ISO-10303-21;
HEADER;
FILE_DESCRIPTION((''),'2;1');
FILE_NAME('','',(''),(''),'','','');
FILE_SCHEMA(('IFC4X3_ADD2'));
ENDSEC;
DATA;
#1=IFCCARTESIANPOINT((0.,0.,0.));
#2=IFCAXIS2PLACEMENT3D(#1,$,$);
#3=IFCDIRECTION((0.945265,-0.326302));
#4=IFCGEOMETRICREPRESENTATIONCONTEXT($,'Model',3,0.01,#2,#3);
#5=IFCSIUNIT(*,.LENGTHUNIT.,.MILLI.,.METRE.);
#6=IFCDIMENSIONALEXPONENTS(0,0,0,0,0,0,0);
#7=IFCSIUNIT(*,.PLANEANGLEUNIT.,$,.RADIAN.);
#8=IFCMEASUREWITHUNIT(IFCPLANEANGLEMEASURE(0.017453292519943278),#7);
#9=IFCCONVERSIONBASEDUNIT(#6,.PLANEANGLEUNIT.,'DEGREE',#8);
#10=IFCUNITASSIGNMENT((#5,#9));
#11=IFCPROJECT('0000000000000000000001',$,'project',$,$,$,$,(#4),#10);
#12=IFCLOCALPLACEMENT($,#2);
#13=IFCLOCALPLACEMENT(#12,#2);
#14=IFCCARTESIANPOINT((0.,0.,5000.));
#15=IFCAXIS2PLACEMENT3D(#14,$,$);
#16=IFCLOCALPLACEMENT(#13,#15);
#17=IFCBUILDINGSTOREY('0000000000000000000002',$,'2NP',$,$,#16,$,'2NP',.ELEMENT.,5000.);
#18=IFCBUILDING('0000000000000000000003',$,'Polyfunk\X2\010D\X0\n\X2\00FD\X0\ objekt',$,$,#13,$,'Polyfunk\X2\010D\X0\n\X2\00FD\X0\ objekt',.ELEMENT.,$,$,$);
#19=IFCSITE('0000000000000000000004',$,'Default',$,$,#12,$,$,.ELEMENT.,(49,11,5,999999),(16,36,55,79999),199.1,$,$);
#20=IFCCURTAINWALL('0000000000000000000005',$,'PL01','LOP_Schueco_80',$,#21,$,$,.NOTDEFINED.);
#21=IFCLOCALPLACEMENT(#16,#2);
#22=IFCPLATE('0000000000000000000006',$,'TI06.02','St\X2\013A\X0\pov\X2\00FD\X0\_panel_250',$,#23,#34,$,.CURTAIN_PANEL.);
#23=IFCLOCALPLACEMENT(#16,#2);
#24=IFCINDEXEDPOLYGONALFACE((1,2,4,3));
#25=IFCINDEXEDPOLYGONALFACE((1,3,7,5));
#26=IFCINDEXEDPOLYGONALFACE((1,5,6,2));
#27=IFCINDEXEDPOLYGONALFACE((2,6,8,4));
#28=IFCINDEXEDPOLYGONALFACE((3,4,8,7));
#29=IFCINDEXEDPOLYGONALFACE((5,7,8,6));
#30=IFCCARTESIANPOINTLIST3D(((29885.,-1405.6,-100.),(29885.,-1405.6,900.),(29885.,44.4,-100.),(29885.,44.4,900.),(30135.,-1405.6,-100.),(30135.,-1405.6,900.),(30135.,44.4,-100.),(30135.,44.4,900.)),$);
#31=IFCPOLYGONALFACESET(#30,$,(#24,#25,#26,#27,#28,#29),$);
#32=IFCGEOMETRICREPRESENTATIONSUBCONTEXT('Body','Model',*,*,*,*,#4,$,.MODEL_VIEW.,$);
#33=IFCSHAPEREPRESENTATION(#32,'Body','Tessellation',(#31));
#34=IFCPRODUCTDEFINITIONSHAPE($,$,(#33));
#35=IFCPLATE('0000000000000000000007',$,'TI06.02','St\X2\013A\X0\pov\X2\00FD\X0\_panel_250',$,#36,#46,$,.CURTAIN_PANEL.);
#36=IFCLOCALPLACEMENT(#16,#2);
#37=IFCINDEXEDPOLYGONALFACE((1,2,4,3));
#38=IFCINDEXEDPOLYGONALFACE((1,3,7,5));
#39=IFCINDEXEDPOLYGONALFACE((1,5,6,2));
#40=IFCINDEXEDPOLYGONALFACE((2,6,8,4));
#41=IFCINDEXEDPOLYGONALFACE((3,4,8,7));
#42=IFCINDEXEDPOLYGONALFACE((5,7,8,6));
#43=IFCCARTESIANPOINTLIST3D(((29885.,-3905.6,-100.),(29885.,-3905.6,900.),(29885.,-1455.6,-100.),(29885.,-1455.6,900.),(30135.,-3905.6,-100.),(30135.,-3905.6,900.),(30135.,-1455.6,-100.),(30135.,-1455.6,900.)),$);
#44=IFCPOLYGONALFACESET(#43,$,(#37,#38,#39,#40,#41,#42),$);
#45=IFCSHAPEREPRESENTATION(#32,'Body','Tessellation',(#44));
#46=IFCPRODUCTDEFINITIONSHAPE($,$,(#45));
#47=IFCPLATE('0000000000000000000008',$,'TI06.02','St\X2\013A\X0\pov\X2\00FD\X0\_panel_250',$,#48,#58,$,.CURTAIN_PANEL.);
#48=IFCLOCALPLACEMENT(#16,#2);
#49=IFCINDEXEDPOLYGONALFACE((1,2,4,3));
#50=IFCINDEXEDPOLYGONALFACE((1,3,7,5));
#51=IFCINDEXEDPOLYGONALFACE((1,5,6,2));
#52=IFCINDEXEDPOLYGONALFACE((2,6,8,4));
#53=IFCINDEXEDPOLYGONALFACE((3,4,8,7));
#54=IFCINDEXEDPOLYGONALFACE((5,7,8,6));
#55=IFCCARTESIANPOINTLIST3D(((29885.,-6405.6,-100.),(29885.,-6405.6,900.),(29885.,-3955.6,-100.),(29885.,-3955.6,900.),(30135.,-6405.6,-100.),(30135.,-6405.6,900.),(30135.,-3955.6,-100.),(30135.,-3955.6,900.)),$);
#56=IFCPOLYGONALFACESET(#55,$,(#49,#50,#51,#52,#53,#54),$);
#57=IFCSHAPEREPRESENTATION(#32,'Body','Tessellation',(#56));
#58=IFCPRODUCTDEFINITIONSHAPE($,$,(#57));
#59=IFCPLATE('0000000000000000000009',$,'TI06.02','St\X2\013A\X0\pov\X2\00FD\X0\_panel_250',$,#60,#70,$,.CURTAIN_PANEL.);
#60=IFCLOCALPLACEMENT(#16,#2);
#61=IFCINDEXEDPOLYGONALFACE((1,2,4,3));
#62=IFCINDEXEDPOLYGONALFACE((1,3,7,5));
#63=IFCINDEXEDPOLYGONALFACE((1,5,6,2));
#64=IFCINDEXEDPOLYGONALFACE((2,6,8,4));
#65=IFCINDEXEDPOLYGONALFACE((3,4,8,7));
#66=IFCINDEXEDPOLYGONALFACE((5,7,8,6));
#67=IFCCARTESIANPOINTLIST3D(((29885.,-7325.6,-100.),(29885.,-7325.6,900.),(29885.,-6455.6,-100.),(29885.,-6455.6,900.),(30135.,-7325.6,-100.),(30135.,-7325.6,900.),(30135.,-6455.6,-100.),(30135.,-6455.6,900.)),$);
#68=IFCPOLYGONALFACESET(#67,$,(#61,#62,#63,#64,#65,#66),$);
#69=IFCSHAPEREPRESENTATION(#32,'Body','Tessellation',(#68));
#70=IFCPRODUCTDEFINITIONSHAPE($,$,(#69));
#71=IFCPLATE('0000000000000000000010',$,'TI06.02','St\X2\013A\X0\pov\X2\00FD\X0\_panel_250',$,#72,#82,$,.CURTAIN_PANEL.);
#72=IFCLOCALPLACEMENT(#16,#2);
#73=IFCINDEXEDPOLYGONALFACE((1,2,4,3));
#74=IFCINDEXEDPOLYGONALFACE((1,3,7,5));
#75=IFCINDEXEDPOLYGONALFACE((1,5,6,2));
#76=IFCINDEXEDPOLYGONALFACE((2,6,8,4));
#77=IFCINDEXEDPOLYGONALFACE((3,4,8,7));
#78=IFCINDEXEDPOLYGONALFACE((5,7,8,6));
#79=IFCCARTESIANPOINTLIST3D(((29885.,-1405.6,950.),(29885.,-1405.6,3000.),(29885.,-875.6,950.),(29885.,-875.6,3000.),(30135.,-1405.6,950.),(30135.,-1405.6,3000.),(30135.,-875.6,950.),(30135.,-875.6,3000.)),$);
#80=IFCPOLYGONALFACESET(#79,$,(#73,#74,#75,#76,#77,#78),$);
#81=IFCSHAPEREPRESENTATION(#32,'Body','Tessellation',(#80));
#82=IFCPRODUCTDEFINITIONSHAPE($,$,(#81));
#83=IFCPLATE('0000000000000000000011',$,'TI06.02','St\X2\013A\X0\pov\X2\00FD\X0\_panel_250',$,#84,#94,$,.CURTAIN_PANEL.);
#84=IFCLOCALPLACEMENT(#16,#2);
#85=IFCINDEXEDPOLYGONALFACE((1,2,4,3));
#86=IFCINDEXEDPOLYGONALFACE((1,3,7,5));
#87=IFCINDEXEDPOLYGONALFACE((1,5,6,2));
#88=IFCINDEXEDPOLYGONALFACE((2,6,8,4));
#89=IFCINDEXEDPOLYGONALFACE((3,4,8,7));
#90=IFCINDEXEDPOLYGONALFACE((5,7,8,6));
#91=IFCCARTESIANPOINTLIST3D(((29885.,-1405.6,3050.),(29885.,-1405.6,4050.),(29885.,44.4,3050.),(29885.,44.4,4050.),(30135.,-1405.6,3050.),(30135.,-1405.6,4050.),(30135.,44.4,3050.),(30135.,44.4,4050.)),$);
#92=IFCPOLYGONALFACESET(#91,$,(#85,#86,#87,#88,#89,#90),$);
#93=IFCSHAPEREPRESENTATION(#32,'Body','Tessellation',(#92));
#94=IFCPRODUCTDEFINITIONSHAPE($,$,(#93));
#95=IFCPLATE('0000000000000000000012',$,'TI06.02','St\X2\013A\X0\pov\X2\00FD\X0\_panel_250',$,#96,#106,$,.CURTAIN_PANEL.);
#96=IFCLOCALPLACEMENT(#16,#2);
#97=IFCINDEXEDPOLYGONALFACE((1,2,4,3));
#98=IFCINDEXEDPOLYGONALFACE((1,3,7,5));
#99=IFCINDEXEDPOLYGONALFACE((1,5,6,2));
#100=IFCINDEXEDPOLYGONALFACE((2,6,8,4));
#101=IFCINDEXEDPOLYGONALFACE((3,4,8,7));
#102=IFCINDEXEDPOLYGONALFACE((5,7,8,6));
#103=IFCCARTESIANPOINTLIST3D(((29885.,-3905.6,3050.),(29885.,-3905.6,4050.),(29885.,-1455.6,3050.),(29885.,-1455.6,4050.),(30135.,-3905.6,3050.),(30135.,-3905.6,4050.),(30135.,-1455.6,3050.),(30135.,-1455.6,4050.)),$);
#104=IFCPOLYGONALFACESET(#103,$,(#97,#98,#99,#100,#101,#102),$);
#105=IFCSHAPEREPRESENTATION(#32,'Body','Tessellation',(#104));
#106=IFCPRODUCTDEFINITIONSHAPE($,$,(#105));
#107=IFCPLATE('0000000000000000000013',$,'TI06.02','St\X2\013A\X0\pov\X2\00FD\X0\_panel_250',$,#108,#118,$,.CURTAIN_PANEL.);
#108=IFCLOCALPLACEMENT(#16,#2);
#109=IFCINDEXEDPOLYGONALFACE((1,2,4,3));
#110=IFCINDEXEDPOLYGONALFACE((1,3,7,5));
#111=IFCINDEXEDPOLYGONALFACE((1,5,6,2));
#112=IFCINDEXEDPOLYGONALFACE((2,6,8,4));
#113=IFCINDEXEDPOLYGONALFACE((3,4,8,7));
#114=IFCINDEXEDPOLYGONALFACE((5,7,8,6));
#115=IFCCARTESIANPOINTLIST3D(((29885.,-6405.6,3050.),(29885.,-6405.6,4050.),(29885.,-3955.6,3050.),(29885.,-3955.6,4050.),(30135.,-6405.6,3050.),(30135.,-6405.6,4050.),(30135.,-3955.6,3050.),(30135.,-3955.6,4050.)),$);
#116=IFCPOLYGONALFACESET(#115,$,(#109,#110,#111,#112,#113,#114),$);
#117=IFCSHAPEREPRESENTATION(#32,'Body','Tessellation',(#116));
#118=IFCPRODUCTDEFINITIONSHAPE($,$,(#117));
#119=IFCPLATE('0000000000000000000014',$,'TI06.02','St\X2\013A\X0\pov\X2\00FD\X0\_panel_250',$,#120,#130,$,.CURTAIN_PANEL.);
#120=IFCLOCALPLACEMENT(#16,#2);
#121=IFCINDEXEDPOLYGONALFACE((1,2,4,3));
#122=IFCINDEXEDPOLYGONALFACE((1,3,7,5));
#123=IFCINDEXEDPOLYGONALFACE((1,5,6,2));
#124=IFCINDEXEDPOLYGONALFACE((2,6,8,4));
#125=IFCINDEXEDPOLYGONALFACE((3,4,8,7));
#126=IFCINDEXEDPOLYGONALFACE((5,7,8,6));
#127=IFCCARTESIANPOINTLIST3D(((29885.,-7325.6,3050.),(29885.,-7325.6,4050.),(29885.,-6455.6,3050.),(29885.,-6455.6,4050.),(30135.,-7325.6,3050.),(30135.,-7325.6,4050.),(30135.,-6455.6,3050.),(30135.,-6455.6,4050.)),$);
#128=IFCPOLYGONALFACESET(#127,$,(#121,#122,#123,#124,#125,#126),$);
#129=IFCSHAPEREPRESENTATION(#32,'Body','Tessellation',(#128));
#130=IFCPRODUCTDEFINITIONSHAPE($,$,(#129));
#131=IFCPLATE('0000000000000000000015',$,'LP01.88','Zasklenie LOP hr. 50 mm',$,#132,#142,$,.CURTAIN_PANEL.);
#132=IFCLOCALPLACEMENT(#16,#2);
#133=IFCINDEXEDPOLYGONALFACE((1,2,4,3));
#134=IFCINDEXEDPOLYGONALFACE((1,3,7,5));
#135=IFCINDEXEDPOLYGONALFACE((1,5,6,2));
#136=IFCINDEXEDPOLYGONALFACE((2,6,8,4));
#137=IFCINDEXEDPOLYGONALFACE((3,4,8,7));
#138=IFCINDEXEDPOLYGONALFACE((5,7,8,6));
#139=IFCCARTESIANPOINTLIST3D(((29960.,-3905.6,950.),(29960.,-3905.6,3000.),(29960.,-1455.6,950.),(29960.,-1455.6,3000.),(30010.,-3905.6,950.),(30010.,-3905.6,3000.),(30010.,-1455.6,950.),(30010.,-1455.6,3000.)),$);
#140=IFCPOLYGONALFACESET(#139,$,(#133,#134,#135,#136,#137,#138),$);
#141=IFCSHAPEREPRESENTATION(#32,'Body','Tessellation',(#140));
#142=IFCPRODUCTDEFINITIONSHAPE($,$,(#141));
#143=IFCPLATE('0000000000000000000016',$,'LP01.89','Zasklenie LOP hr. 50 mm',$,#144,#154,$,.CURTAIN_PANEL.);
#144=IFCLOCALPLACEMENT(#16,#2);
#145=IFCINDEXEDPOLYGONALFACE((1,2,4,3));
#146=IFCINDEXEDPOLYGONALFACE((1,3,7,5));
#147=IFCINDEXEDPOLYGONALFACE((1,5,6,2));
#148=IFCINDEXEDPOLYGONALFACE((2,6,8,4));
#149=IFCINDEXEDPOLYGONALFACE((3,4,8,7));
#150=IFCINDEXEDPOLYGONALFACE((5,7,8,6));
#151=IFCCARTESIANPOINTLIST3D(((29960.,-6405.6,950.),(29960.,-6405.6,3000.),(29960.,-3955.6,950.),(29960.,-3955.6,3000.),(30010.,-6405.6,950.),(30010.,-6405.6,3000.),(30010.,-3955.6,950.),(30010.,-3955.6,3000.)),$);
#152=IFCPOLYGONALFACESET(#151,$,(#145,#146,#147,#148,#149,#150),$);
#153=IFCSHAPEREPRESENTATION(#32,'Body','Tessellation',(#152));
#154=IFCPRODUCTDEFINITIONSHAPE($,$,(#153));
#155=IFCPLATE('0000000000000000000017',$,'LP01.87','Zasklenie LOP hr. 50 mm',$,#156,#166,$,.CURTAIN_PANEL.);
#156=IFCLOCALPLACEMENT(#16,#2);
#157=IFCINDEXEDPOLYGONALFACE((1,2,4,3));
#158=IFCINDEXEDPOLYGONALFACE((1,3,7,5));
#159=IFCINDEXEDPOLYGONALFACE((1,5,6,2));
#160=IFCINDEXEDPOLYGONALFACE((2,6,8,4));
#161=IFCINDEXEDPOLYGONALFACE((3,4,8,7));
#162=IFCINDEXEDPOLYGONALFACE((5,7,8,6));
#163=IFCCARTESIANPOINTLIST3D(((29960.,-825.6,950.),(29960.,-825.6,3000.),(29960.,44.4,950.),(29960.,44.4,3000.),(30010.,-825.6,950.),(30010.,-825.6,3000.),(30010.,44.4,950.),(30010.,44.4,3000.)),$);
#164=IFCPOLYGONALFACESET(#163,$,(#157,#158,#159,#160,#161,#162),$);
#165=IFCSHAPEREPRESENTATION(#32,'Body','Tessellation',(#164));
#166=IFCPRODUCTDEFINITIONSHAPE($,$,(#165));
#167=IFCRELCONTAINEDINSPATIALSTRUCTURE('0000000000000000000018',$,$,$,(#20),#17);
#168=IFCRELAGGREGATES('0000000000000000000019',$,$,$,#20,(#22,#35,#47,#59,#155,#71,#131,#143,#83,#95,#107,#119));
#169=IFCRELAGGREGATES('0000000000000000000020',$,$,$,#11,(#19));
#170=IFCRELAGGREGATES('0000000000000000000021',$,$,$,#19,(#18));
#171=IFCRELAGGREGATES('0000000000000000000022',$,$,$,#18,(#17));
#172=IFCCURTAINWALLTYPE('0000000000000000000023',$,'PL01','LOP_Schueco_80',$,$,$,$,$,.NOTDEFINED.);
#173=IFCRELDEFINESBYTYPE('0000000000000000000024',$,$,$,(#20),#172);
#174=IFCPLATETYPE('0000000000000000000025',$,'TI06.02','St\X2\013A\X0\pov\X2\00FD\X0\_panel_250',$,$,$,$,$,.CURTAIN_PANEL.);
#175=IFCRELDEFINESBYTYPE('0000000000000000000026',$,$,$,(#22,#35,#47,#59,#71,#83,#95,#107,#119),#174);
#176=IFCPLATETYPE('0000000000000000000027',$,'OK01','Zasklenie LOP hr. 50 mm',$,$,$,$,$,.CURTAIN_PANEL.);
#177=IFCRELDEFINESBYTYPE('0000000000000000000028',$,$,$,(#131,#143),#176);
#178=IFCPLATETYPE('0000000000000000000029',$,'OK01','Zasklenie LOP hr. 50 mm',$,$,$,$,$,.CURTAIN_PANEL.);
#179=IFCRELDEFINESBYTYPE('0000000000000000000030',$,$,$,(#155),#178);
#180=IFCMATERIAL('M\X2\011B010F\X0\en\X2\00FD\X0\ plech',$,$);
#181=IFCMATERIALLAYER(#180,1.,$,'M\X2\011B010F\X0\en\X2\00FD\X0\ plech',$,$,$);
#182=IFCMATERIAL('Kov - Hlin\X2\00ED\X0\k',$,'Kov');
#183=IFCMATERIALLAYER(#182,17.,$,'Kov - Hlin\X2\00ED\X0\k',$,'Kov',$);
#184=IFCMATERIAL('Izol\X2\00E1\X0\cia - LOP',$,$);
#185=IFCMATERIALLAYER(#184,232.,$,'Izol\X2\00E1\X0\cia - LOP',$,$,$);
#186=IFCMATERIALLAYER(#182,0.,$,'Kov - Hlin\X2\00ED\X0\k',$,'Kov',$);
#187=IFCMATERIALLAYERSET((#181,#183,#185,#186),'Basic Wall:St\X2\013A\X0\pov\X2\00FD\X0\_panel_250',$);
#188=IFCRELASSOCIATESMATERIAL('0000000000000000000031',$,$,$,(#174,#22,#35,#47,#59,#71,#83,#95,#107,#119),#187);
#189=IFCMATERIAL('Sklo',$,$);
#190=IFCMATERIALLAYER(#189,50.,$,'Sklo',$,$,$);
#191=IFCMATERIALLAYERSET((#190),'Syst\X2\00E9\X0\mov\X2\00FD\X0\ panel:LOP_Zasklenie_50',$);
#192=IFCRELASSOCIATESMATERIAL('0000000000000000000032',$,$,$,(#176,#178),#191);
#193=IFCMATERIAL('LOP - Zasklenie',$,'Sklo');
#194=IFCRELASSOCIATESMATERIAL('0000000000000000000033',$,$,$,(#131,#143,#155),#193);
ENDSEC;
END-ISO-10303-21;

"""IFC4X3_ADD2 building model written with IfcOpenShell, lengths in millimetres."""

from ifc_helpers import new_model, entity, si_unit, converted_unit, direction, frame, frame_2d, origin, origin_2d_with_axis, place, context, subcontext, project, spatial, rectangle, extrude, source, transform, mapped, material, layer, layer_set, layer_usage, type_object, type_shapes, element, aggregate, save


model = new_model("IFC4X3_ADD2")

# Units and contexts
model_context = context("Model", 3, precision=0.01, world=origin(), true_north=direction((0.945265, -0.326302)))
body_context = subcontext(model_context, "Body", "Model", "MODEL_VIEW")
ifc_project = project(units=[si_unit("LENGTHUNIT", "METRE", prefix="MILLI"), converted_unit("PLANEANGLEUNIT", "DEGREE", entity("IfcPlaneAngleMeasure", 0.017453292519943278), si_unit("PLANEANGLEUNIT", "RADIAN"), dimensions=[0, 0, 0, 0, 0, 0, 0])], contexts=[model_context])

# Site, building, storey
site_placement = place(None, origin())
site = spatial("IfcSite", under=ifc_project, at=site_placement, Name="Default", CompositionType="ELEMENT", RefLatitude=(49, 11, 5, 999999), RefLongitude=(16, 36, 55, 79999), RefElevation=199.1)
building_placement = place(site_placement, origin())
building = spatial("IfcBuilding", under=site, at=building_placement, Name="Polyfunkčný objekt", LongName="Polyfunkčný objekt", CompositionType="ELEMENT")
storey_placement = place(building_placement, frame((0.0, 0.0, 5000.0)))
storey = spatial("IfcBuildingStorey", under=building, at=storey_placement, Name="2NP", LongName="2NP", CompositionType="ELEMENT", Elevation=5000.0)

# Curtain wall, plates
curtain_wall_type = type_object("IfcCurtainWallType", Name="PL01", Description="LOP_Schueco_80", PredefinedType="NOTDEFINED")
curtain_wall_placement = place(storey_placement, frame((0.0, 0.0, -5000.0)))
curtain_wall = element("IfcCurtainWall", 1, at=curtain_wall_placement, inside=storey, type_object=curtain_wall_type, Name="PL01", Description="LOP_Schueco_80", PredefinedType="NOTDEFINED")
ifc_material_1 = material(Name="Měďený plech")
ifc_layer_1 = layer(ifc_material_1, 1.0, Name="Měďený plech")
ifc_material_2 = material(Name="Kov - Hliník", Category="Kov")
ifc_layer_2 = layer(ifc_material_2, 17.0, Name="Kov - Hliník", Category="Kov")
ifc_material_3 = material(Name="Izolácia - LOP")
ifc_layer_3 = layer(ifc_material_3, 232.0, Name="Izolácia - LOP")
ifc_layer_4 = layer(ifc_material_2, 0.0, Name="Kov - Hliník", Category="Kov")
ifc_layer_set_1 = layer_set([ifc_layer_1, ifc_layer_2, ifc_layer_3, ifc_layer_4], Name="Basic Wall:Stĺpový_panel_250")
ifc_layer_usage_1 = layer_usage(ifc_layer_set_1, "AXIS2", "POSITIVE", -125.0)
plate_type_1 = type_object("IfcPlateType", Name="TI06.02", Description="Stĺpový_panel_250", PredefinedType="CURTAIN_PANEL", material=ifc_layer_set_1)
plate_1_placement = place(storey_placement, frame((30010.0, 44.4, -100.0), z_axis=(0.0, 0.0, 1.0), x_axis=(0.0, -1.0, 0.0)))
plate_1 = element("IfcPlate", 2, at=plate_1_placement, type_object=plate_type_1, material=ifc_layer_usage_1, Name="TI06.02", Description="Stĺpový_panel_250", PredefinedType="CURTAIN_PANEL", context=body_context, shape_type="SweptSolid", body=[
    extrude(rectangle(XDim=250.0, YDim=1450.0, at=frame_2d((0.0, 0.0), x_axis=(1.0, 0.0))), frame((725.0, 0.0, 0.0), z_axis=(0.0, 0.0, 1.0), x_axis=(0.0, 1.0, 0.0)), (0.0, 0.0, 1.0), 1000.0),
])
ifc_layer_usage_2 = layer_usage(ifc_layer_set_1, "AXIS2", "POSITIVE", -125.0)
plate_2_placement = place(storey_placement, frame((30010.0, -1455.6, -100.0), z_axis=(0.0, 0.0, 1.0), x_axis=(0.0, -1.0, 0.0)))
plate_2 = element("IfcPlate", 3, at=plate_2_placement, type_object=plate_type_1, material=ifc_layer_usage_2, Name="TI06.02", Description="Stĺpový_panel_250", PredefinedType="CURTAIN_PANEL", context=body_context, shape_type="SweptSolid", body=[
    extrude(rectangle(XDim=250.0, YDim=2450.0, at=origin_2d_with_axis()), frame((1225.0, 0.0, 0.0), z_axis=(0.0, 0.0, 1.0), x_axis=(0.0, 1.0, 0.0)), (0.0, 0.0, 1.0), 1000.0),
])
ifc_layer_usage_3 = layer_usage(ifc_layer_set_1, "AXIS2", "POSITIVE", -125.0)
plate_3_placement = place(storey_placement, frame((30010.0, -3955.6, -100.0), z_axis=(0.0, 0.0, 1.0), x_axis=(0.0, -1.0, 0.0)))
plate_3 = element("IfcPlate", 4, at=plate_3_placement, type_object=plate_type_1, material=ifc_layer_usage_3, Name="TI06.02", Description="Stĺpový_panel_250", PredefinedType="CURTAIN_PANEL", context=body_context, shape_type="SweptSolid", body=[
    extrude(rectangle(XDim=250.0, YDim=2450.0, at=frame_2d((0.0, 0.0), x_axis=(1.0, 0.0))), frame((1225.0, 0.0, 0.0), z_axis=(0.0, 0.0, 1.0), x_axis=(0.0, 1.0, 0.0)), (0.0, 0.0, 1.0), 1000.0),
])
ifc_layer_usage_4 = layer_usage(ifc_layer_set_1, "AXIS2", "POSITIVE", -125.0)
plate_4_placement = place(storey_placement, frame((30010.0, -6455.6, -100.0), z_axis=(0.0, 0.0, 1.0), x_axis=(0.0, -1.0, 0.0)))
plate_4 = element("IfcPlate", 5, at=plate_4_placement, type_object=plate_type_1, material=ifc_layer_usage_4, Name="TI06.02", Description="Stĺpový_panel_250", PredefinedType="CURTAIN_PANEL", context=body_context, shape_type="SweptSolid", body=[
    extrude(rectangle(XDim=250.0, YDim=870.0, at=frame_2d((0.0, 0.0), x_axis=(1.0, 0.0))), frame((435.0, 0.0, 0.0), z_axis=(0.0, 0.0, 1.0), x_axis=(0.0, 1.0, 0.0)), (0.0, 0.0, 1.0), 1000.0),
])
ifc_layer_usage_5 = layer_usage(ifc_layer_set_1, "AXIS2", "POSITIVE", -125.0)
plate_5_placement = place(storey_placement, frame((30010.0, -875.6, 950.0), z_axis=(0.0, 0.0, 1.0), x_axis=(0.0, -1.0, 0.0)))
plate_5 = element("IfcPlate", 6, at=plate_5_placement, type_object=plate_type_1, material=ifc_layer_usage_5, Name="TI06.02", Description="Stĺpový_panel_250", PredefinedType="CURTAIN_PANEL", context=body_context, shape_type="SweptSolid", body=[
    extrude(rectangle(XDim=250.0, YDim=530.0, at=frame_2d((0.0, 0.0), x_axis=(1.0, 0.0))), frame((265.0, 0.0, 0.0), z_axis=(0.0, 0.0, 1.0), x_axis=(0.0, 1.0, 0.0)), (0.0, 0.0, 1.0), 2050.0),
])
ifc_layer_usage_6 = layer_usage(ifc_layer_set_1, "AXIS2", "POSITIVE", -125.0)
plate_6_placement = place(storey_placement, frame((30010.0, 44.4, 3050.0), z_axis=(0.0, 0.0, 1.0), x_axis=(0.0, -1.0, 0.0)))
plate_6 = element("IfcPlate", 7, at=plate_6_placement, type_object=plate_type_1, material=ifc_layer_usage_6, Name="TI06.02", Description="Stĺpový_panel_250", PredefinedType="CURTAIN_PANEL", context=body_context, shape_type="SweptSolid", body=[
    extrude(rectangle(XDim=250.0, YDim=1450.0, at=frame_2d((0.0, 0.0), x_axis=(1.0, 0.0))), frame((725.0, 0.0, 0.0), z_axis=(0.0, 0.0, 1.0), x_axis=(0.0, 1.0, 0.0)), (0.0, 0.0, 1.0), 1000.0),
])
ifc_layer_usage_7 = layer_usage(ifc_layer_set_1, "AXIS2", "POSITIVE", -125.0)
plate_7_placement = place(storey_placement, frame((30010.0, -1455.6, 3050.0), z_axis=(0.0, 0.0, 1.0), x_axis=(0.0, -1.0, 0.0)))
plate_7 = element("IfcPlate", 8, at=plate_7_placement, type_object=plate_type_1, material=ifc_layer_usage_7, Name="TI06.02", Description="Stĺpový_panel_250", PredefinedType="CURTAIN_PANEL", context=body_context, shape_type="SweptSolid", body=[
    extrude(rectangle(XDim=250.0, YDim=2450.0, at=origin_2d_with_axis()), frame((1225.0, 0.0, 0.0), z_axis=(0.0, 0.0, 1.0), x_axis=(0.0, 1.0, 0.0)), (0.0, 0.0, 1.0), 1000.0),
])
ifc_layer_usage_8 = layer_usage(ifc_layer_set_1, "AXIS2", "POSITIVE", -125.0)
plate_8_placement = place(storey_placement, frame((30010.0, -3955.6, 3050.0), z_axis=(0.0, 0.0, 1.0), x_axis=(0.0, -1.0, 0.0)))
plate_8 = element("IfcPlate", 9, at=plate_8_placement, type_object=plate_type_1, material=ifc_layer_usage_8, Name="TI06.02", Description="Stĺpový_panel_250", PredefinedType="CURTAIN_PANEL", context=body_context, shape_type="SweptSolid", body=[
    extrude(rectangle(XDim=250.0, YDim=2450.0, at=frame_2d((0.0, 0.0), x_axis=(1.0, 0.0))), frame((1225.0, 0.0, 0.0), z_axis=(0.0, 0.0, 1.0), x_axis=(0.0, 1.0, 0.0)), (0.0, 0.0, 1.0), 1000.0),
])
ifc_layer_usage_9 = layer_usage(ifc_layer_set_1, "AXIS2", "POSITIVE", -125.0)
plate_9_placement = place(storey_placement, frame((30010.0, -6455.6, 3050.0), z_axis=(0.0, 0.0, 1.0), x_axis=(0.0, -1.0, 0.0)))
plate_9 = element("IfcPlate", 10, at=plate_9_placement, type_object=plate_type_1, material=ifc_layer_usage_9, Name="TI06.02", Description="Stĺpový_panel_250", PredefinedType="CURTAIN_PANEL", context=body_context, shape_type="SweptSolid", body=[
    extrude(rectangle(XDim=250.0, YDim=870.0, at=frame_2d((0.0, 0.0), x_axis=(1.0, 0.0))), frame((435.0, 0.0, 0.0), z_axis=(0.0, 0.0, 1.0), x_axis=(0.0, 1.0, 0.0)), (0.0, 0.0, 1.0), 1000.0),
])
ifc_material_4 = material(Name="LOP - Zasklenie", Category="Sklo")
ifc_material_5 = material(Name="Sklo")
ifc_layer_5 = layer(ifc_material_5, 50.0, Name="Sklo")
ifc_layer_set_2 = layer_set([ifc_layer_5], Name="Systémový panel:LOP_Zasklenie_50")
plate_type_2 = type_object("IfcPlateType", Name="OK01", Description="Zasklenie LOP hr. 50 mm", PredefinedType="CURTAIN_PANEL", material=ifc_layer_set_2)
shared_shape_1 = source(origin(), body_context, "Body", "SweptSolid", [
    extrude(rectangle(XDim=50.0, YDim=2450.0, at=origin_2d_with_axis()), frame((0.0, -25.0, 0.0), z_axis=(0.0, 0.0, 1.0), x_axis=(0.0, 1.0, 0.0)), (0.0, 0.0, 1.0), 2050.0),
])
type_shapes(plate_type_2, [shared_shape_1])
plate_10_placement = place(curtain_wall_placement, frame((30010.0, -2680.6, 5950.0), z_axis=(0.0, 0.0, 1.0), x_axis=(0.0, -1.0, 0.0)))
plate_10 = element("IfcPlate", 11, at=plate_10_placement, type_object=plate_type_2, material=ifc_material_4, Name="LP01.88", Description="Zasklenie LOP hr. 50 mm", PredefinedType="CURTAIN_PANEL", context=body_context, shape_type="MappedRepresentation", body=[
    mapped(shared_shape_1, transform((0.0, 0.0, 0.0), scale=1.0)),
])
plate_11_placement = place(curtain_wall_placement, frame((30010.0, -5180.6, 5950.0), z_axis=(0.0, 0.0, 1.0), x_axis=(0.0, -1.0, 0.0)))
plate_11 = element("IfcPlate", 12, at=plate_11_placement, type_object=plate_type_2, material=ifc_material_4, Name="LP01.89", Description="Zasklenie LOP hr. 50 mm", PredefinedType="CURTAIN_PANEL", context=body_context, shape_type="MappedRepresentation", body=[
    mapped(shared_shape_1, transform((0.0, 0.0, 0.0), scale=1.0)),
])
plate_type_3 = type_object("IfcPlateType", Name="OK01", Description="Zasklenie LOP hr. 50 mm", PredefinedType="CURTAIN_PANEL", material=ifc_layer_set_2)
shared_shape_2 = source(origin(), body_context, "Body", "SweptSolid", [
    extrude(rectangle(XDim=50.0, YDim=870.0, at=origin_2d_with_axis()), frame((0.0, -25.0, 0.0), z_axis=(0.0, 0.0, 1.0), x_axis=(0.0, 1.0, 0.0)), (0.0, 0.0, 1.0), 2050.0),
])
type_shapes(plate_type_3, [shared_shape_2])
plate_12_placement = place(curtain_wall_placement, frame((30010.0, -390.6, 5950.0), z_axis=(0.0, 0.0, 1.0), x_axis=(0.0, -1.0, 0.0)))
plate_12 = element("IfcPlate", 13, at=plate_12_placement, type_object=plate_type_3, material=ifc_material_4, Name="LP01.87", Description="Zasklenie LOP hr. 50 mm", PredefinedType="CURTAIN_PANEL", context=body_context, shape_type="MappedRepresentation", body=[
    mapped(shared_shape_2, transform((0.0, 0.0, 0.0), scale=1.0)),
])
aggregate(curtain_wall, [plate_1, plate_2, plate_3, plate_4, plate_12, plate_5, plate_10, plate_11, plate_6, plate_7, plate_8, plate_9])

save(model, "model.ifc")
